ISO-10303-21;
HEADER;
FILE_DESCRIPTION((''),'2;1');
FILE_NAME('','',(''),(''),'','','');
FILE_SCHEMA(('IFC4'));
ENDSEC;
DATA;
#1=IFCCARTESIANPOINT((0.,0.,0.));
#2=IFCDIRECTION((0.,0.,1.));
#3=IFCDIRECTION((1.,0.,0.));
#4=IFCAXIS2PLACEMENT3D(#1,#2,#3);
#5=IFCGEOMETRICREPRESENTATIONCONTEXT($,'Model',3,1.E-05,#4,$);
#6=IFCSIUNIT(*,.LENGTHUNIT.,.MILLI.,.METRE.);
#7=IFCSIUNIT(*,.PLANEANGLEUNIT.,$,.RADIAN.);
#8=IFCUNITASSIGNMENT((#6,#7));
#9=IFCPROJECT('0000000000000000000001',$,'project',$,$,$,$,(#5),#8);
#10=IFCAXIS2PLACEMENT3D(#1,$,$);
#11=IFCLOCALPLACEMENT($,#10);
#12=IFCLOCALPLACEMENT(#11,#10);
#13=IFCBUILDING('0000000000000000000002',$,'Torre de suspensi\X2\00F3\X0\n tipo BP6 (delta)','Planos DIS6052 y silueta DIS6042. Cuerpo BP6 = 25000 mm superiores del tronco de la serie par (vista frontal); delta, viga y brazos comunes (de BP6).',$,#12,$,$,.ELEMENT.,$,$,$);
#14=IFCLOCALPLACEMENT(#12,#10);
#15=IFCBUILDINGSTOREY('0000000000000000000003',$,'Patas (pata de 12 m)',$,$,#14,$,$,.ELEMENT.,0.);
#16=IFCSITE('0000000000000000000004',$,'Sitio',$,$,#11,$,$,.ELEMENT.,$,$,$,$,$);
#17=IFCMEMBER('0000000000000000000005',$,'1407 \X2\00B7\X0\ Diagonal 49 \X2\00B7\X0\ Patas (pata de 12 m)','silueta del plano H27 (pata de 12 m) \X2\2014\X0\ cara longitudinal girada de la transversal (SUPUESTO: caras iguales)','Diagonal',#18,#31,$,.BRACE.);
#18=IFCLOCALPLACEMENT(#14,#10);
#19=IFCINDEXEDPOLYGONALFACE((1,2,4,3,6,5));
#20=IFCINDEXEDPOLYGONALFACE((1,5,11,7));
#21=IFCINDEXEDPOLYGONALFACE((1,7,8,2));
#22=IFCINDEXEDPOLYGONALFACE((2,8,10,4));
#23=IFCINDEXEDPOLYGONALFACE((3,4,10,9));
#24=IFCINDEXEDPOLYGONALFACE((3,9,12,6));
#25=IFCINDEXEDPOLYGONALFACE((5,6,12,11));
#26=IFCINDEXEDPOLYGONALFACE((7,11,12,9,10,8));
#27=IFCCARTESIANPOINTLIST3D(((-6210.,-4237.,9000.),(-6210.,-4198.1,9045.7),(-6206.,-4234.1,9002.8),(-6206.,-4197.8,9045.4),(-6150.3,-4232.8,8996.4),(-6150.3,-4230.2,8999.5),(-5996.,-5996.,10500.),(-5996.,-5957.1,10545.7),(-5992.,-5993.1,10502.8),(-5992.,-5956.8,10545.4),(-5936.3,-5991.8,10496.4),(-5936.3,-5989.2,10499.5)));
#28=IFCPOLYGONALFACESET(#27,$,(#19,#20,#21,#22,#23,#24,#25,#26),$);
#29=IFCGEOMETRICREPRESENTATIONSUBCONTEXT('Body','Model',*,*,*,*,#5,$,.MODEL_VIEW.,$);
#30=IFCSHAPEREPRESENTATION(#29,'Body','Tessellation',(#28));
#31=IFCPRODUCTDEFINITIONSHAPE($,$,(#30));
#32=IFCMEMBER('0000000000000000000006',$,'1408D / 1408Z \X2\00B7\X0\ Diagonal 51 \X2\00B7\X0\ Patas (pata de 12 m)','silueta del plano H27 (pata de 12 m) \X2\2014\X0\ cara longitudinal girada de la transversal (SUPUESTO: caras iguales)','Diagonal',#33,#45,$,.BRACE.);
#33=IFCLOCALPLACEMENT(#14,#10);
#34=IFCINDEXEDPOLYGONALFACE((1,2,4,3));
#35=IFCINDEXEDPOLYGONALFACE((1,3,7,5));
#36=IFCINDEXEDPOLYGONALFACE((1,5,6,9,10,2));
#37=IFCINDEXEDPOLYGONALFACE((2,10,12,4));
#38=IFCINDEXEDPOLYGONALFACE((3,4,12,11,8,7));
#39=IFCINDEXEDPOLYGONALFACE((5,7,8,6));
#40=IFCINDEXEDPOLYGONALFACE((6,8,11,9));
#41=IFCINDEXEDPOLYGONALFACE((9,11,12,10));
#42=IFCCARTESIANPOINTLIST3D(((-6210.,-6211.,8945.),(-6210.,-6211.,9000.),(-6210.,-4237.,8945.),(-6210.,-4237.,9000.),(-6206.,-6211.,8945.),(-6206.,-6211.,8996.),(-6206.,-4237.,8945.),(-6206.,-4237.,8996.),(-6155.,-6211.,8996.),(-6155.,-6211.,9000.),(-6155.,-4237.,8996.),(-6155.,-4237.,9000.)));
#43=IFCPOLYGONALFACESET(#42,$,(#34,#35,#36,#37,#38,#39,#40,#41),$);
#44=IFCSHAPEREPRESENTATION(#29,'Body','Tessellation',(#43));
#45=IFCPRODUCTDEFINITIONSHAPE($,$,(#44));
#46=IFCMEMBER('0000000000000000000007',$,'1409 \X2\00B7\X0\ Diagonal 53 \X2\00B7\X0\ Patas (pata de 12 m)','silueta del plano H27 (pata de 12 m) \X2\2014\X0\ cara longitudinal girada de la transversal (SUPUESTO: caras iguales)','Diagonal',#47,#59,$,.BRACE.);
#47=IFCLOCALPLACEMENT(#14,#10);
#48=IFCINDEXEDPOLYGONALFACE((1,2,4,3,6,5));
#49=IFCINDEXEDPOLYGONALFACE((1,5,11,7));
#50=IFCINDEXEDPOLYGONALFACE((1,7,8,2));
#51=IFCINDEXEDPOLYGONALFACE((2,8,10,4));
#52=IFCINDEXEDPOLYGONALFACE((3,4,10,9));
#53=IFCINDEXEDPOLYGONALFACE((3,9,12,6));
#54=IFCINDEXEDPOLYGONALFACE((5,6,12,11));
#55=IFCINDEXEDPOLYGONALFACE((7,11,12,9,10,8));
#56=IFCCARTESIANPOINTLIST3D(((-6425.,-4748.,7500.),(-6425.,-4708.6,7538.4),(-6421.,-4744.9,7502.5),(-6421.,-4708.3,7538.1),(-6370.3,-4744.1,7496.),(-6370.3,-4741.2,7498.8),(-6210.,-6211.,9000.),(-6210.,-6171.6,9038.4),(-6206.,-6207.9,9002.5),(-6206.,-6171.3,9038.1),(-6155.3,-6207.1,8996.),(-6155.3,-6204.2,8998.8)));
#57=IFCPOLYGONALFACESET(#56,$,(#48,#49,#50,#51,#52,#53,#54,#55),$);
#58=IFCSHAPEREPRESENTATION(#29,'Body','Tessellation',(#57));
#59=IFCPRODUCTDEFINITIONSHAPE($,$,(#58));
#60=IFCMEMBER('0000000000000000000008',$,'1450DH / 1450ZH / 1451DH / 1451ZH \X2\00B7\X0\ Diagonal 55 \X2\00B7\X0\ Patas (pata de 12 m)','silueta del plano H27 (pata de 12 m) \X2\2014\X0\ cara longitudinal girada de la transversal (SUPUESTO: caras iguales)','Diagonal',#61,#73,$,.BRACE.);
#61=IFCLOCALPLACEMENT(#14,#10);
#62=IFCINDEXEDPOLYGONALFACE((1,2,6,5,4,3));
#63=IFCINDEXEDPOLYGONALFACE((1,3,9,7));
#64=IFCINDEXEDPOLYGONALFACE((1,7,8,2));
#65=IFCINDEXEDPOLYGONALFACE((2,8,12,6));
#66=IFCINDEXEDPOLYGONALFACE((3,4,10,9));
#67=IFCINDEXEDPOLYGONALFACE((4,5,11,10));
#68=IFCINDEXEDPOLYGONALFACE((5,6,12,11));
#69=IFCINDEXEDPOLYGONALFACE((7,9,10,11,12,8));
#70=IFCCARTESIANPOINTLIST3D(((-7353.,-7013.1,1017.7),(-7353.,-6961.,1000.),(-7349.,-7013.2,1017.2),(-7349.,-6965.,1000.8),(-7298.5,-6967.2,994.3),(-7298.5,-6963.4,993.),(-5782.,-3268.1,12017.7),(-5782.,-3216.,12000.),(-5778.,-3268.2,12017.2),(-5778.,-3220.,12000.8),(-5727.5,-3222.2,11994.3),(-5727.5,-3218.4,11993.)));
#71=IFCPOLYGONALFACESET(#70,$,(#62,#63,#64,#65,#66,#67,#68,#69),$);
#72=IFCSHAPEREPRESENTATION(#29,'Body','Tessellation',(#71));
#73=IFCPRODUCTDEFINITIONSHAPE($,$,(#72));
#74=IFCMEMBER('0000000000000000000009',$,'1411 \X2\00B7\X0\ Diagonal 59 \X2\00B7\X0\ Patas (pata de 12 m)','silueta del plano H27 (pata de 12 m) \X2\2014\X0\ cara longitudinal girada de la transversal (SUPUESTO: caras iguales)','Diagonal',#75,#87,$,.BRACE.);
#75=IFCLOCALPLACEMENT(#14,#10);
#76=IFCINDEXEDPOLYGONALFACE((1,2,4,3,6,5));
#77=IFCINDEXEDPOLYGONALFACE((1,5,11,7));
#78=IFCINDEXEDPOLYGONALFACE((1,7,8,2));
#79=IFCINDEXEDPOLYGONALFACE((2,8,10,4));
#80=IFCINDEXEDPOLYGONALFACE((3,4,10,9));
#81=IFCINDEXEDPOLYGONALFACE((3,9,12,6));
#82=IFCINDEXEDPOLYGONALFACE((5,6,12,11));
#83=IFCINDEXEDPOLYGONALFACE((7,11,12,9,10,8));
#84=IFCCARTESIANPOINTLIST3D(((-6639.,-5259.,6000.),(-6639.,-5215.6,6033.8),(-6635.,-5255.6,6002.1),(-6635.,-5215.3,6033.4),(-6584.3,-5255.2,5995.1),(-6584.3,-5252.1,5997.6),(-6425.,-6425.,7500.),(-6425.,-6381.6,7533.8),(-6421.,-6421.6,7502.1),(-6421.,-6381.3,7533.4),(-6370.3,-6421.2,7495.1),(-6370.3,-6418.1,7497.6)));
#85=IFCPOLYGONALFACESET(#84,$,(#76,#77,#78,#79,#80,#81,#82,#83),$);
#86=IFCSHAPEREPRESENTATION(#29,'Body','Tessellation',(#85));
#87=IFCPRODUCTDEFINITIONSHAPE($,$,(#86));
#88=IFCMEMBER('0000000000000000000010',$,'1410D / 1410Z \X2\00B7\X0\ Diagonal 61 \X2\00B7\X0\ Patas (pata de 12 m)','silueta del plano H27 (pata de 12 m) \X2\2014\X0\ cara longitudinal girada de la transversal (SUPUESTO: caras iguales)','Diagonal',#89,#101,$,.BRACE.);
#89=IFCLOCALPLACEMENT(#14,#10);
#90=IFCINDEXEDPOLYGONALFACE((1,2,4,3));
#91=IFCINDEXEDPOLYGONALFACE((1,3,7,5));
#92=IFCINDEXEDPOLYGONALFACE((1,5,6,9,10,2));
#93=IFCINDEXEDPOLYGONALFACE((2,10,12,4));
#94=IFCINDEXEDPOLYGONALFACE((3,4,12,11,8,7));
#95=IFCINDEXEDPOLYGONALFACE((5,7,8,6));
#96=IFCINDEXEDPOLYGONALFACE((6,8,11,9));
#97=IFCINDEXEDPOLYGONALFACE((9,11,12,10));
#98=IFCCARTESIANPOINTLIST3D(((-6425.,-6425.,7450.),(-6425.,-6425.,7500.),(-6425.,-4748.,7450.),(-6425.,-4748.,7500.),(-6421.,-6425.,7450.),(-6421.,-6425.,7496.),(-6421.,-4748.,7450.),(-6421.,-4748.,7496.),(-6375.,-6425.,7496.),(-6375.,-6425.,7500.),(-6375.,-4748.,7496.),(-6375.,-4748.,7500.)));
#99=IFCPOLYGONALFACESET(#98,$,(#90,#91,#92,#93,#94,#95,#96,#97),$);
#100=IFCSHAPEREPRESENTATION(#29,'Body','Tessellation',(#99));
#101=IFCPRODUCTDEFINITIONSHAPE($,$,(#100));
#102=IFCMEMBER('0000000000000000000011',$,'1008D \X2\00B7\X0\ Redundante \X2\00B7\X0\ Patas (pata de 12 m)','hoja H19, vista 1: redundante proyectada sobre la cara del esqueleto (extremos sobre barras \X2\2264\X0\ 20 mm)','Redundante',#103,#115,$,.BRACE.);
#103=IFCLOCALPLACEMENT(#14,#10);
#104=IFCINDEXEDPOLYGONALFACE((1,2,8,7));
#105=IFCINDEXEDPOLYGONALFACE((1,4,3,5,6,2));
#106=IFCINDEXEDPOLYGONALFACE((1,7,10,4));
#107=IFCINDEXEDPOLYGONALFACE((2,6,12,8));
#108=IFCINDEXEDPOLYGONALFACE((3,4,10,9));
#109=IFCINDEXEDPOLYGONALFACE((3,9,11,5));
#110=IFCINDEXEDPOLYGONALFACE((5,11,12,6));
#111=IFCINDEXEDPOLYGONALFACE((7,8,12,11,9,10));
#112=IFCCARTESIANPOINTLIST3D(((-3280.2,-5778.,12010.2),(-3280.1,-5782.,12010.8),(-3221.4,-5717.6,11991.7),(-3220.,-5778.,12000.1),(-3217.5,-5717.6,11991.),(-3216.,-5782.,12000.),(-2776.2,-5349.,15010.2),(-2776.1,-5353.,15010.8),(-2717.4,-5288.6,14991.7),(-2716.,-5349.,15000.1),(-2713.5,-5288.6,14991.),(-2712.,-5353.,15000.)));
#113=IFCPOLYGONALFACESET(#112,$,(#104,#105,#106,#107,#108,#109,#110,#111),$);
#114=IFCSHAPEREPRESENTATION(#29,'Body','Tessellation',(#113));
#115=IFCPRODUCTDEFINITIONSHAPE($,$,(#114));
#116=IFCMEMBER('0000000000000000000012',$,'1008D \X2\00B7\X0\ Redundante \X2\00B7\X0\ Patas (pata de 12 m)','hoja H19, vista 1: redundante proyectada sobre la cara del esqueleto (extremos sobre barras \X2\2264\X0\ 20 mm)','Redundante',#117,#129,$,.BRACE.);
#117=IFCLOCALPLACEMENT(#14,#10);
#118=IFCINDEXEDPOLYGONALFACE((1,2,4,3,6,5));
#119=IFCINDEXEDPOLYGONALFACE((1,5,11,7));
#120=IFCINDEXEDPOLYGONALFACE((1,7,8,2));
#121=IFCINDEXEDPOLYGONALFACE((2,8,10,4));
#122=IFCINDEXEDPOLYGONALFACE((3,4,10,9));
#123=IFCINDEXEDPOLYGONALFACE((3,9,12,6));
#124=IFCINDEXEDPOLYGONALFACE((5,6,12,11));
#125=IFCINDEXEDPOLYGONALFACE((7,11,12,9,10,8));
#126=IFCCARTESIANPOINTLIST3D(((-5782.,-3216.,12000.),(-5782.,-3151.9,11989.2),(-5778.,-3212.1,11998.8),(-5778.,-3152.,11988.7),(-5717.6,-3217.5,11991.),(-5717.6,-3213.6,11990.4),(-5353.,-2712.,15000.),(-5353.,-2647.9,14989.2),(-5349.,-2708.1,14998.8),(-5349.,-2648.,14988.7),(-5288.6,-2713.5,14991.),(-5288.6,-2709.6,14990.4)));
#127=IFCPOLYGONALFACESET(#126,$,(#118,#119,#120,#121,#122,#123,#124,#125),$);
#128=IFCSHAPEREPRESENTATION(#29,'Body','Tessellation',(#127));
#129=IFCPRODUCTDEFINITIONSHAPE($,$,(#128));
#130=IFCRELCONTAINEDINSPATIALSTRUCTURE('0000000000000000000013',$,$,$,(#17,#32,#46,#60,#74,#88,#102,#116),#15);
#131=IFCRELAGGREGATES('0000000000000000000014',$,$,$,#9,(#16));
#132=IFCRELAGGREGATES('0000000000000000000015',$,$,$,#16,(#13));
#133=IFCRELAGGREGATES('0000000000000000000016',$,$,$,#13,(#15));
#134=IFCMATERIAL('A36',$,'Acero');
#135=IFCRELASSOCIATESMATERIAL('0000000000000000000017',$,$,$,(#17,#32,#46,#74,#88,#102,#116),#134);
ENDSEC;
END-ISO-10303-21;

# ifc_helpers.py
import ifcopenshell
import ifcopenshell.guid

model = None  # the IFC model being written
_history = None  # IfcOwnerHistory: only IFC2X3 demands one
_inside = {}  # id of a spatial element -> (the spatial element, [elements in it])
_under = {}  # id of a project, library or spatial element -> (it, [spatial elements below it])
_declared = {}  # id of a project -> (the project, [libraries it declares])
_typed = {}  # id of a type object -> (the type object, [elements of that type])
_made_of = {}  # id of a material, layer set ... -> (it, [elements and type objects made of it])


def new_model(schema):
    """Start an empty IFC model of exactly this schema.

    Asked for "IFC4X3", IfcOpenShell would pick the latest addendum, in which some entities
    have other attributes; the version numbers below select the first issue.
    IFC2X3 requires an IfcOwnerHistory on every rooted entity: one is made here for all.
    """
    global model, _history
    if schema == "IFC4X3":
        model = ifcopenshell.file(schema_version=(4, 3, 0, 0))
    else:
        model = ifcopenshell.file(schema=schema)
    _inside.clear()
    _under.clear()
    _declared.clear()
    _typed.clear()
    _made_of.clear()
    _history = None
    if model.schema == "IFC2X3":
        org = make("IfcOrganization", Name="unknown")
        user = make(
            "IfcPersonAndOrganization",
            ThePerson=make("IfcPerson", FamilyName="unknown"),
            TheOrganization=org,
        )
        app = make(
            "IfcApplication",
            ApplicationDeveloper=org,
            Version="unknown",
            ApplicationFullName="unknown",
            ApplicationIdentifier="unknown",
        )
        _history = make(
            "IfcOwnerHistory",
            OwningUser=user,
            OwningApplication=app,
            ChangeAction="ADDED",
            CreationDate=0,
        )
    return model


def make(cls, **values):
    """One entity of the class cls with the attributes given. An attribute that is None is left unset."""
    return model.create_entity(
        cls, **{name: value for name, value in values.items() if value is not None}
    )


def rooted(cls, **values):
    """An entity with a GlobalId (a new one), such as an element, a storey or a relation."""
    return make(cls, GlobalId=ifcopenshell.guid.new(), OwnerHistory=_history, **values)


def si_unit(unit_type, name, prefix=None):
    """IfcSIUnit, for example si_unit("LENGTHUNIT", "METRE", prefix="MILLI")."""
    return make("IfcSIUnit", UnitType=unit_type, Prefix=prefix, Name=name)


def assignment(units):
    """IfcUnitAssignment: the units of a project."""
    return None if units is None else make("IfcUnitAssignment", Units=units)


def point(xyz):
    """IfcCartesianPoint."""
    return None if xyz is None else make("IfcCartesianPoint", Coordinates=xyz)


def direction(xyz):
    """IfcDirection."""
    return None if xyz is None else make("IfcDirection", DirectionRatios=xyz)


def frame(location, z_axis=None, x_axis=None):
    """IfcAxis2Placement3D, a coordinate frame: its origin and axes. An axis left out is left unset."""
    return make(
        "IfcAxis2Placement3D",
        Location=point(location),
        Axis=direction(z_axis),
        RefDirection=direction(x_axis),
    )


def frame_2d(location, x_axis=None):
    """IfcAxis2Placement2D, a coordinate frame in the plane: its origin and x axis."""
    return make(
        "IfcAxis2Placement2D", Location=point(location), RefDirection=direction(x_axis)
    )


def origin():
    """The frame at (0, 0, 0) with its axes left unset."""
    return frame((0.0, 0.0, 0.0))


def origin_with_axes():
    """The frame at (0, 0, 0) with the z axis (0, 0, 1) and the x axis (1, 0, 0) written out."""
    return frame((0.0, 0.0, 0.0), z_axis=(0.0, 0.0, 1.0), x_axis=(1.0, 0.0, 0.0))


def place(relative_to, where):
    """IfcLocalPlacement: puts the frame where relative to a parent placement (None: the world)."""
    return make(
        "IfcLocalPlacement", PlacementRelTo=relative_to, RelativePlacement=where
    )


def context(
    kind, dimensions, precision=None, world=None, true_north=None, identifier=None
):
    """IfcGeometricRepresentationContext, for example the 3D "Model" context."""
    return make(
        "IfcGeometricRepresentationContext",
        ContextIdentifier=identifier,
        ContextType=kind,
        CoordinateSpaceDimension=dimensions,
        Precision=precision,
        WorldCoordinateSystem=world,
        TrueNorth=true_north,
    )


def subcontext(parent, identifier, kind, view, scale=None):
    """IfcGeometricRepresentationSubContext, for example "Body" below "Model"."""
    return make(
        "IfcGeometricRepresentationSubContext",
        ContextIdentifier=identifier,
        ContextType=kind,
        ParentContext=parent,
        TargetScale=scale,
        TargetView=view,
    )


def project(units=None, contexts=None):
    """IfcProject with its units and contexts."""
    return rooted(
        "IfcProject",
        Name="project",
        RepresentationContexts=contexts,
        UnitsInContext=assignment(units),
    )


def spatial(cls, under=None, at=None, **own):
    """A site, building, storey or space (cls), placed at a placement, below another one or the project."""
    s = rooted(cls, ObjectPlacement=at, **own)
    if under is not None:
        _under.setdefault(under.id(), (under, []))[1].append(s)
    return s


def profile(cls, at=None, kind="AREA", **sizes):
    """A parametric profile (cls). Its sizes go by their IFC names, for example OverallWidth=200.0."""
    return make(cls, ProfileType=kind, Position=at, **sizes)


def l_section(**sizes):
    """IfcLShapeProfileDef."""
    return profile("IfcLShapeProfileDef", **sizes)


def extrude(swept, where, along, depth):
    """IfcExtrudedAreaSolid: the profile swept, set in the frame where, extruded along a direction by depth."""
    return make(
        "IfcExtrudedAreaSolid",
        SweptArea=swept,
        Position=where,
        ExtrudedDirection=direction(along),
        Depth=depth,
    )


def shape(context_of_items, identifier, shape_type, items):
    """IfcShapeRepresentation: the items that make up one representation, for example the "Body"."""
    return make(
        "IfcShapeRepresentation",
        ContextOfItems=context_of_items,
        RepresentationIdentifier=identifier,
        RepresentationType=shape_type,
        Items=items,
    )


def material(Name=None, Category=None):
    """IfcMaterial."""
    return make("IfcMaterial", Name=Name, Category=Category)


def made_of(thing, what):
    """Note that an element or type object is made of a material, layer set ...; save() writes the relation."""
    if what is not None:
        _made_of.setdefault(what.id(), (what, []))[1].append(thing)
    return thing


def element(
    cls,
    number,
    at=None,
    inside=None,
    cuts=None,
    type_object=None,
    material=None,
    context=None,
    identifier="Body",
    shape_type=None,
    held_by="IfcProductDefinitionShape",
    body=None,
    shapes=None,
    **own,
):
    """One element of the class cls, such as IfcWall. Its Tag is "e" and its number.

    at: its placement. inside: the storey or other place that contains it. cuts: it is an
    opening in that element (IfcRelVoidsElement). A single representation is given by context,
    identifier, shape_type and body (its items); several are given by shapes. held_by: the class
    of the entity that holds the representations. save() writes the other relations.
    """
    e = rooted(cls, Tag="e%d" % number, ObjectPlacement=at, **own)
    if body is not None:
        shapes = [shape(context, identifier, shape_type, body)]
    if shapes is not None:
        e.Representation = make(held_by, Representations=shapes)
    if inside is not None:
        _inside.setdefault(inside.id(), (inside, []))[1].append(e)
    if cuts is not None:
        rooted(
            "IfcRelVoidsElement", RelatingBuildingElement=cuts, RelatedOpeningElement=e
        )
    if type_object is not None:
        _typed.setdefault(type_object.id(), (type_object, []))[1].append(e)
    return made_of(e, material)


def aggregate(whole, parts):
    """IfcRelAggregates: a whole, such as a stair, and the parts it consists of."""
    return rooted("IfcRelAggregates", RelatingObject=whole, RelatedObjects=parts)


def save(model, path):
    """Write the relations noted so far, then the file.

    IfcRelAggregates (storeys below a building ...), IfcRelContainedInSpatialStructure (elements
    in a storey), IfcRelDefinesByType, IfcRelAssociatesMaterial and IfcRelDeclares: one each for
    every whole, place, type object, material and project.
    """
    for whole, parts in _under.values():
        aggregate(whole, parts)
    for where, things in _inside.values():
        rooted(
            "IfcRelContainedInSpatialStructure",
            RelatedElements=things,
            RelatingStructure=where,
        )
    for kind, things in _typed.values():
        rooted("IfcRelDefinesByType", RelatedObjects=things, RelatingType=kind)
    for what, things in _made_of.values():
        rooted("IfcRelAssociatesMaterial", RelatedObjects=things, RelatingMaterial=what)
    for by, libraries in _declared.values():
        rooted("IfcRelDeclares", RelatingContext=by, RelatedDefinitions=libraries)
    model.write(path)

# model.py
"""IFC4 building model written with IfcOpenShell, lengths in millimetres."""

from ifc_helpers import new_model, si_unit, frame, frame_2d, origin, origin_with_axes, place, context, subcontext, project, spatial, l_section, extrude, material, element, save


model = new_model("IFC4")

# Units and contexts
model_context = context("Model", 3, precision=1e-05, world=origin_with_axes())
body_context = subcontext(model_context, "Body", "Model", "MODEL_VIEW")
ifc_project = project(units=[si_unit("LENGTHUNIT", "METRE", prefix="MILLI"), si_unit("PLANEANGLEUNIT", "RADIAN")], contexts=[model_context])

# Site, building, storey
site_placement = place(None, origin())
site = spatial("IfcSite", under=ifc_project, at=site_placement, Name="Sitio", CompositionType="ELEMENT")
building_placement = place(site_placement, origin())
building = spatial("IfcBuilding", under=site, at=building_placement, Name="Torre de suspensión tipo BP6 (delta)", Description="Planos DIS6052 y silueta DIS6042. Cuerpo BP6 = 25000 mm superiores del tronco de la serie par (vista frontal); delta, viga y brazos comunes (de BP6).", CompositionType="ELEMENT")
storey_placement = place(building_placement, origin())
storey = spatial("IfcBuildingStorey", under=building, at=storey_placement, Name="Patas (pata de 12 m)", CompositionType="ELEMENT", Elevation=0.0)

# Members
ifc_material_1 = material(Name="A36", Category="Acero")
member_1_placement = place(storey_placement, frame((-6210.0, -4237.0, 9000.0), z_axis=(0.092177, -0.757664, 0.646103), x_axis=(0.995743, 0.070138, -0.059811)))
element("IfcMember", 1, at=member_1_placement, inside=storey, material=ifc_material_1, Name="1407 · Diagonal 49 · Patas (pata de 12 m)", Description="silueta del plano H27 (pata de 12 m) — cara longitudinal girada de la transversal (SUPUESTO: caras iguales)", ObjectType="Diagonal", PredefinedType="BRACE", context=body_context, shape_type="SweptSolid", body=[
    extrude(l_section(Depth=60.0, Width=60.0, Thickness=4.0, at=frame_2d((30.0, 30.0))), None, (0.0, 0.0, 1.0), 2321.6),
])
member_2_placement = place(storey_placement, frame((-6210.0, -6211.0, 9000.0), z_axis=(0.0, 1.0, 0.0), x_axis=(1.0, 0.0, 0.0)))
element("IfcMember", 2, at=member_2_placement, inside=storey, material=ifc_material_1, Name="1408D / 1408Z · Diagonal 51 · Patas (pata de 12 m)", Description="silueta del plano H27 (pata de 12 m) — cara longitudinal girada de la transversal (SUPUESTO: caras iguales)", ObjectType="Diagonal", PredefinedType="BRACE", context=body_context, shape_type="SweptSolid", body=[
    extrude(l_section(Depth=55.0, Width=55.0, Thickness=4.0, at=frame_2d((27.5, 27.5))), None, (0.0, 0.0, 1.0), 1974.0),
])
member_3_placement = place(storey_placement, frame((-6425.0, -4748.0, 7500.0), z_axis=(0.102074, -0.694576, 0.712142), x_axis=(0.994777, 0.07127, -0.073073)))
element("IfcMember", 3, at=member_3_placement, inside=storey, material=ifc_material_1, Name="1409 · Diagonal 53 · Patas (pata de 12 m)", Description="silueta del plano H27 (pata de 12 m) — cara longitudinal girada de la transversal (SUPUESTO: caras iguales)", ObjectType="Diagonal", PredefinedType="BRACE", context=body_context, shape_type="SweptSolid", body=[
    extrude(l_section(Depth=55.0, Width=55.0, Thickness=4.0, at=frame_2d((27.5, 27.5))), None, (0.0, 0.0, 1.0), 2106.3),
])
member_4_placement = place(storey_placement, frame((-5782.0, -3216.0, 12000.0), z_axis=(-0.133979, -0.319383, -0.938107), x_axis=(0.990984, -0.04318, -0.12683)))
element("IfcMember", 4, at=member_4_placement, inside=storey, Name="1450DH / 1450ZH / 1451DH / 1451ZH · Diagonal 55 · Patas (pata de 12 m)", Description="silueta del plano H27 (pata de 12 m) — cara longitudinal girada de la transversal (SUPUESTO: caras iguales)", ObjectType="Diagonal", PredefinedType="BRACE", context=body_context, shape_type="SweptSolid", body=[
    extrude(l_section(Depth=55.0, Width=55.0, Thickness=4.0, at=frame_2d((27.5, 27.5))), None, (0.0, 0.0, 1.0), 11725.7),
])
member_5_placement = place(storey_placement, frame((-6639.0, -5259.0, 6000.0), z_axis=(0.111931, -0.609865, 0.784561), x_axis=(0.993716, 0.068694, -0.088372)))
element("IfcMember", 5, at=member_5_placement, inside=storey, material=ifc_material_1, Name="1411 · Diagonal 59 · Patas (pata de 12 m)", Description="silueta del plano H27 (pata de 12 m) — cara longitudinal girada de la transversal (SUPUESTO: caras iguales)", ObjectType="Diagonal", PredefinedType="BRACE", context=body_context, shape_type="SweptSolid", body=[
    extrude(l_section(Depth=55.0, Width=55.0, Thickness=4.0, at=frame_2d((27.5, 27.5))), None, (0.0, 0.0, 1.0), 1911.9),
])
member_6_placement = place(storey_placement, frame((-6425.0, -6425.0, 7500.0), z_axis=(0.0, 1.0, 0.0), x_axis=(1.0, 0.0, 0.0)))
element("IfcMember", 6, at=member_6_placement, inside=storey, material=ifc_material_1, Name="1410D / 1410Z · Diagonal 61 · Patas (pata de 12 m)", Description="silueta del plano H27 (pata de 12 m) — cara longitudinal girada de la transversal (SUPUESTO: caras iguales)", ObjectType="Diagonal", PredefinedType="BRACE", context=body_context, shape_type="SweptSolid", body=[
    extrude(l_section(Depth=50.0, Width=50.0, Thickness=4.0, at=frame_2d((25.0, 25.0))), None, (0.0, 0.0, 1.0), 1677.0),
])
for number, where, z_axis, x_axis, name in (
    (7, (-3216.0, -5782.0, 12000.0), (0.164055, 0.139642, 0.976517), (-0.023136, 0.990202, -0.137712), "1008D · Redundante · Patas (pata de 12 m)"),
    (8, (-5782.0, -3216.0, 12000.0), (0.139642, 0.164055, 0.976517), (0.990202, -0.023136, -0.137712), "1008D · Redundante · Patas (pata de 12 m)"),
):
    element("IfcMember", number, at=place(storey_placement, frame(where, z_axis=z_axis, x_axis=x_axis)), inside=storey, material=ifc_material_1, Name=name, Description="hoja H19, vista 1: redundante proyectada sobre la cara del esqueleto (extremos sobre barras ≤ 20 mm)", ObjectType="Redundante", PredefinedType="BRACE", context=body_context, shape_type="SweptSolid", body=[
        extrude(l_section(Depth=65.0, Width=65.0, Thickness=4.0, at=frame_2d((32.5, 32.5))), None, (0.0, 0.0, 1.0), 3072.1),
    ])

save(model, "model.ifc")
